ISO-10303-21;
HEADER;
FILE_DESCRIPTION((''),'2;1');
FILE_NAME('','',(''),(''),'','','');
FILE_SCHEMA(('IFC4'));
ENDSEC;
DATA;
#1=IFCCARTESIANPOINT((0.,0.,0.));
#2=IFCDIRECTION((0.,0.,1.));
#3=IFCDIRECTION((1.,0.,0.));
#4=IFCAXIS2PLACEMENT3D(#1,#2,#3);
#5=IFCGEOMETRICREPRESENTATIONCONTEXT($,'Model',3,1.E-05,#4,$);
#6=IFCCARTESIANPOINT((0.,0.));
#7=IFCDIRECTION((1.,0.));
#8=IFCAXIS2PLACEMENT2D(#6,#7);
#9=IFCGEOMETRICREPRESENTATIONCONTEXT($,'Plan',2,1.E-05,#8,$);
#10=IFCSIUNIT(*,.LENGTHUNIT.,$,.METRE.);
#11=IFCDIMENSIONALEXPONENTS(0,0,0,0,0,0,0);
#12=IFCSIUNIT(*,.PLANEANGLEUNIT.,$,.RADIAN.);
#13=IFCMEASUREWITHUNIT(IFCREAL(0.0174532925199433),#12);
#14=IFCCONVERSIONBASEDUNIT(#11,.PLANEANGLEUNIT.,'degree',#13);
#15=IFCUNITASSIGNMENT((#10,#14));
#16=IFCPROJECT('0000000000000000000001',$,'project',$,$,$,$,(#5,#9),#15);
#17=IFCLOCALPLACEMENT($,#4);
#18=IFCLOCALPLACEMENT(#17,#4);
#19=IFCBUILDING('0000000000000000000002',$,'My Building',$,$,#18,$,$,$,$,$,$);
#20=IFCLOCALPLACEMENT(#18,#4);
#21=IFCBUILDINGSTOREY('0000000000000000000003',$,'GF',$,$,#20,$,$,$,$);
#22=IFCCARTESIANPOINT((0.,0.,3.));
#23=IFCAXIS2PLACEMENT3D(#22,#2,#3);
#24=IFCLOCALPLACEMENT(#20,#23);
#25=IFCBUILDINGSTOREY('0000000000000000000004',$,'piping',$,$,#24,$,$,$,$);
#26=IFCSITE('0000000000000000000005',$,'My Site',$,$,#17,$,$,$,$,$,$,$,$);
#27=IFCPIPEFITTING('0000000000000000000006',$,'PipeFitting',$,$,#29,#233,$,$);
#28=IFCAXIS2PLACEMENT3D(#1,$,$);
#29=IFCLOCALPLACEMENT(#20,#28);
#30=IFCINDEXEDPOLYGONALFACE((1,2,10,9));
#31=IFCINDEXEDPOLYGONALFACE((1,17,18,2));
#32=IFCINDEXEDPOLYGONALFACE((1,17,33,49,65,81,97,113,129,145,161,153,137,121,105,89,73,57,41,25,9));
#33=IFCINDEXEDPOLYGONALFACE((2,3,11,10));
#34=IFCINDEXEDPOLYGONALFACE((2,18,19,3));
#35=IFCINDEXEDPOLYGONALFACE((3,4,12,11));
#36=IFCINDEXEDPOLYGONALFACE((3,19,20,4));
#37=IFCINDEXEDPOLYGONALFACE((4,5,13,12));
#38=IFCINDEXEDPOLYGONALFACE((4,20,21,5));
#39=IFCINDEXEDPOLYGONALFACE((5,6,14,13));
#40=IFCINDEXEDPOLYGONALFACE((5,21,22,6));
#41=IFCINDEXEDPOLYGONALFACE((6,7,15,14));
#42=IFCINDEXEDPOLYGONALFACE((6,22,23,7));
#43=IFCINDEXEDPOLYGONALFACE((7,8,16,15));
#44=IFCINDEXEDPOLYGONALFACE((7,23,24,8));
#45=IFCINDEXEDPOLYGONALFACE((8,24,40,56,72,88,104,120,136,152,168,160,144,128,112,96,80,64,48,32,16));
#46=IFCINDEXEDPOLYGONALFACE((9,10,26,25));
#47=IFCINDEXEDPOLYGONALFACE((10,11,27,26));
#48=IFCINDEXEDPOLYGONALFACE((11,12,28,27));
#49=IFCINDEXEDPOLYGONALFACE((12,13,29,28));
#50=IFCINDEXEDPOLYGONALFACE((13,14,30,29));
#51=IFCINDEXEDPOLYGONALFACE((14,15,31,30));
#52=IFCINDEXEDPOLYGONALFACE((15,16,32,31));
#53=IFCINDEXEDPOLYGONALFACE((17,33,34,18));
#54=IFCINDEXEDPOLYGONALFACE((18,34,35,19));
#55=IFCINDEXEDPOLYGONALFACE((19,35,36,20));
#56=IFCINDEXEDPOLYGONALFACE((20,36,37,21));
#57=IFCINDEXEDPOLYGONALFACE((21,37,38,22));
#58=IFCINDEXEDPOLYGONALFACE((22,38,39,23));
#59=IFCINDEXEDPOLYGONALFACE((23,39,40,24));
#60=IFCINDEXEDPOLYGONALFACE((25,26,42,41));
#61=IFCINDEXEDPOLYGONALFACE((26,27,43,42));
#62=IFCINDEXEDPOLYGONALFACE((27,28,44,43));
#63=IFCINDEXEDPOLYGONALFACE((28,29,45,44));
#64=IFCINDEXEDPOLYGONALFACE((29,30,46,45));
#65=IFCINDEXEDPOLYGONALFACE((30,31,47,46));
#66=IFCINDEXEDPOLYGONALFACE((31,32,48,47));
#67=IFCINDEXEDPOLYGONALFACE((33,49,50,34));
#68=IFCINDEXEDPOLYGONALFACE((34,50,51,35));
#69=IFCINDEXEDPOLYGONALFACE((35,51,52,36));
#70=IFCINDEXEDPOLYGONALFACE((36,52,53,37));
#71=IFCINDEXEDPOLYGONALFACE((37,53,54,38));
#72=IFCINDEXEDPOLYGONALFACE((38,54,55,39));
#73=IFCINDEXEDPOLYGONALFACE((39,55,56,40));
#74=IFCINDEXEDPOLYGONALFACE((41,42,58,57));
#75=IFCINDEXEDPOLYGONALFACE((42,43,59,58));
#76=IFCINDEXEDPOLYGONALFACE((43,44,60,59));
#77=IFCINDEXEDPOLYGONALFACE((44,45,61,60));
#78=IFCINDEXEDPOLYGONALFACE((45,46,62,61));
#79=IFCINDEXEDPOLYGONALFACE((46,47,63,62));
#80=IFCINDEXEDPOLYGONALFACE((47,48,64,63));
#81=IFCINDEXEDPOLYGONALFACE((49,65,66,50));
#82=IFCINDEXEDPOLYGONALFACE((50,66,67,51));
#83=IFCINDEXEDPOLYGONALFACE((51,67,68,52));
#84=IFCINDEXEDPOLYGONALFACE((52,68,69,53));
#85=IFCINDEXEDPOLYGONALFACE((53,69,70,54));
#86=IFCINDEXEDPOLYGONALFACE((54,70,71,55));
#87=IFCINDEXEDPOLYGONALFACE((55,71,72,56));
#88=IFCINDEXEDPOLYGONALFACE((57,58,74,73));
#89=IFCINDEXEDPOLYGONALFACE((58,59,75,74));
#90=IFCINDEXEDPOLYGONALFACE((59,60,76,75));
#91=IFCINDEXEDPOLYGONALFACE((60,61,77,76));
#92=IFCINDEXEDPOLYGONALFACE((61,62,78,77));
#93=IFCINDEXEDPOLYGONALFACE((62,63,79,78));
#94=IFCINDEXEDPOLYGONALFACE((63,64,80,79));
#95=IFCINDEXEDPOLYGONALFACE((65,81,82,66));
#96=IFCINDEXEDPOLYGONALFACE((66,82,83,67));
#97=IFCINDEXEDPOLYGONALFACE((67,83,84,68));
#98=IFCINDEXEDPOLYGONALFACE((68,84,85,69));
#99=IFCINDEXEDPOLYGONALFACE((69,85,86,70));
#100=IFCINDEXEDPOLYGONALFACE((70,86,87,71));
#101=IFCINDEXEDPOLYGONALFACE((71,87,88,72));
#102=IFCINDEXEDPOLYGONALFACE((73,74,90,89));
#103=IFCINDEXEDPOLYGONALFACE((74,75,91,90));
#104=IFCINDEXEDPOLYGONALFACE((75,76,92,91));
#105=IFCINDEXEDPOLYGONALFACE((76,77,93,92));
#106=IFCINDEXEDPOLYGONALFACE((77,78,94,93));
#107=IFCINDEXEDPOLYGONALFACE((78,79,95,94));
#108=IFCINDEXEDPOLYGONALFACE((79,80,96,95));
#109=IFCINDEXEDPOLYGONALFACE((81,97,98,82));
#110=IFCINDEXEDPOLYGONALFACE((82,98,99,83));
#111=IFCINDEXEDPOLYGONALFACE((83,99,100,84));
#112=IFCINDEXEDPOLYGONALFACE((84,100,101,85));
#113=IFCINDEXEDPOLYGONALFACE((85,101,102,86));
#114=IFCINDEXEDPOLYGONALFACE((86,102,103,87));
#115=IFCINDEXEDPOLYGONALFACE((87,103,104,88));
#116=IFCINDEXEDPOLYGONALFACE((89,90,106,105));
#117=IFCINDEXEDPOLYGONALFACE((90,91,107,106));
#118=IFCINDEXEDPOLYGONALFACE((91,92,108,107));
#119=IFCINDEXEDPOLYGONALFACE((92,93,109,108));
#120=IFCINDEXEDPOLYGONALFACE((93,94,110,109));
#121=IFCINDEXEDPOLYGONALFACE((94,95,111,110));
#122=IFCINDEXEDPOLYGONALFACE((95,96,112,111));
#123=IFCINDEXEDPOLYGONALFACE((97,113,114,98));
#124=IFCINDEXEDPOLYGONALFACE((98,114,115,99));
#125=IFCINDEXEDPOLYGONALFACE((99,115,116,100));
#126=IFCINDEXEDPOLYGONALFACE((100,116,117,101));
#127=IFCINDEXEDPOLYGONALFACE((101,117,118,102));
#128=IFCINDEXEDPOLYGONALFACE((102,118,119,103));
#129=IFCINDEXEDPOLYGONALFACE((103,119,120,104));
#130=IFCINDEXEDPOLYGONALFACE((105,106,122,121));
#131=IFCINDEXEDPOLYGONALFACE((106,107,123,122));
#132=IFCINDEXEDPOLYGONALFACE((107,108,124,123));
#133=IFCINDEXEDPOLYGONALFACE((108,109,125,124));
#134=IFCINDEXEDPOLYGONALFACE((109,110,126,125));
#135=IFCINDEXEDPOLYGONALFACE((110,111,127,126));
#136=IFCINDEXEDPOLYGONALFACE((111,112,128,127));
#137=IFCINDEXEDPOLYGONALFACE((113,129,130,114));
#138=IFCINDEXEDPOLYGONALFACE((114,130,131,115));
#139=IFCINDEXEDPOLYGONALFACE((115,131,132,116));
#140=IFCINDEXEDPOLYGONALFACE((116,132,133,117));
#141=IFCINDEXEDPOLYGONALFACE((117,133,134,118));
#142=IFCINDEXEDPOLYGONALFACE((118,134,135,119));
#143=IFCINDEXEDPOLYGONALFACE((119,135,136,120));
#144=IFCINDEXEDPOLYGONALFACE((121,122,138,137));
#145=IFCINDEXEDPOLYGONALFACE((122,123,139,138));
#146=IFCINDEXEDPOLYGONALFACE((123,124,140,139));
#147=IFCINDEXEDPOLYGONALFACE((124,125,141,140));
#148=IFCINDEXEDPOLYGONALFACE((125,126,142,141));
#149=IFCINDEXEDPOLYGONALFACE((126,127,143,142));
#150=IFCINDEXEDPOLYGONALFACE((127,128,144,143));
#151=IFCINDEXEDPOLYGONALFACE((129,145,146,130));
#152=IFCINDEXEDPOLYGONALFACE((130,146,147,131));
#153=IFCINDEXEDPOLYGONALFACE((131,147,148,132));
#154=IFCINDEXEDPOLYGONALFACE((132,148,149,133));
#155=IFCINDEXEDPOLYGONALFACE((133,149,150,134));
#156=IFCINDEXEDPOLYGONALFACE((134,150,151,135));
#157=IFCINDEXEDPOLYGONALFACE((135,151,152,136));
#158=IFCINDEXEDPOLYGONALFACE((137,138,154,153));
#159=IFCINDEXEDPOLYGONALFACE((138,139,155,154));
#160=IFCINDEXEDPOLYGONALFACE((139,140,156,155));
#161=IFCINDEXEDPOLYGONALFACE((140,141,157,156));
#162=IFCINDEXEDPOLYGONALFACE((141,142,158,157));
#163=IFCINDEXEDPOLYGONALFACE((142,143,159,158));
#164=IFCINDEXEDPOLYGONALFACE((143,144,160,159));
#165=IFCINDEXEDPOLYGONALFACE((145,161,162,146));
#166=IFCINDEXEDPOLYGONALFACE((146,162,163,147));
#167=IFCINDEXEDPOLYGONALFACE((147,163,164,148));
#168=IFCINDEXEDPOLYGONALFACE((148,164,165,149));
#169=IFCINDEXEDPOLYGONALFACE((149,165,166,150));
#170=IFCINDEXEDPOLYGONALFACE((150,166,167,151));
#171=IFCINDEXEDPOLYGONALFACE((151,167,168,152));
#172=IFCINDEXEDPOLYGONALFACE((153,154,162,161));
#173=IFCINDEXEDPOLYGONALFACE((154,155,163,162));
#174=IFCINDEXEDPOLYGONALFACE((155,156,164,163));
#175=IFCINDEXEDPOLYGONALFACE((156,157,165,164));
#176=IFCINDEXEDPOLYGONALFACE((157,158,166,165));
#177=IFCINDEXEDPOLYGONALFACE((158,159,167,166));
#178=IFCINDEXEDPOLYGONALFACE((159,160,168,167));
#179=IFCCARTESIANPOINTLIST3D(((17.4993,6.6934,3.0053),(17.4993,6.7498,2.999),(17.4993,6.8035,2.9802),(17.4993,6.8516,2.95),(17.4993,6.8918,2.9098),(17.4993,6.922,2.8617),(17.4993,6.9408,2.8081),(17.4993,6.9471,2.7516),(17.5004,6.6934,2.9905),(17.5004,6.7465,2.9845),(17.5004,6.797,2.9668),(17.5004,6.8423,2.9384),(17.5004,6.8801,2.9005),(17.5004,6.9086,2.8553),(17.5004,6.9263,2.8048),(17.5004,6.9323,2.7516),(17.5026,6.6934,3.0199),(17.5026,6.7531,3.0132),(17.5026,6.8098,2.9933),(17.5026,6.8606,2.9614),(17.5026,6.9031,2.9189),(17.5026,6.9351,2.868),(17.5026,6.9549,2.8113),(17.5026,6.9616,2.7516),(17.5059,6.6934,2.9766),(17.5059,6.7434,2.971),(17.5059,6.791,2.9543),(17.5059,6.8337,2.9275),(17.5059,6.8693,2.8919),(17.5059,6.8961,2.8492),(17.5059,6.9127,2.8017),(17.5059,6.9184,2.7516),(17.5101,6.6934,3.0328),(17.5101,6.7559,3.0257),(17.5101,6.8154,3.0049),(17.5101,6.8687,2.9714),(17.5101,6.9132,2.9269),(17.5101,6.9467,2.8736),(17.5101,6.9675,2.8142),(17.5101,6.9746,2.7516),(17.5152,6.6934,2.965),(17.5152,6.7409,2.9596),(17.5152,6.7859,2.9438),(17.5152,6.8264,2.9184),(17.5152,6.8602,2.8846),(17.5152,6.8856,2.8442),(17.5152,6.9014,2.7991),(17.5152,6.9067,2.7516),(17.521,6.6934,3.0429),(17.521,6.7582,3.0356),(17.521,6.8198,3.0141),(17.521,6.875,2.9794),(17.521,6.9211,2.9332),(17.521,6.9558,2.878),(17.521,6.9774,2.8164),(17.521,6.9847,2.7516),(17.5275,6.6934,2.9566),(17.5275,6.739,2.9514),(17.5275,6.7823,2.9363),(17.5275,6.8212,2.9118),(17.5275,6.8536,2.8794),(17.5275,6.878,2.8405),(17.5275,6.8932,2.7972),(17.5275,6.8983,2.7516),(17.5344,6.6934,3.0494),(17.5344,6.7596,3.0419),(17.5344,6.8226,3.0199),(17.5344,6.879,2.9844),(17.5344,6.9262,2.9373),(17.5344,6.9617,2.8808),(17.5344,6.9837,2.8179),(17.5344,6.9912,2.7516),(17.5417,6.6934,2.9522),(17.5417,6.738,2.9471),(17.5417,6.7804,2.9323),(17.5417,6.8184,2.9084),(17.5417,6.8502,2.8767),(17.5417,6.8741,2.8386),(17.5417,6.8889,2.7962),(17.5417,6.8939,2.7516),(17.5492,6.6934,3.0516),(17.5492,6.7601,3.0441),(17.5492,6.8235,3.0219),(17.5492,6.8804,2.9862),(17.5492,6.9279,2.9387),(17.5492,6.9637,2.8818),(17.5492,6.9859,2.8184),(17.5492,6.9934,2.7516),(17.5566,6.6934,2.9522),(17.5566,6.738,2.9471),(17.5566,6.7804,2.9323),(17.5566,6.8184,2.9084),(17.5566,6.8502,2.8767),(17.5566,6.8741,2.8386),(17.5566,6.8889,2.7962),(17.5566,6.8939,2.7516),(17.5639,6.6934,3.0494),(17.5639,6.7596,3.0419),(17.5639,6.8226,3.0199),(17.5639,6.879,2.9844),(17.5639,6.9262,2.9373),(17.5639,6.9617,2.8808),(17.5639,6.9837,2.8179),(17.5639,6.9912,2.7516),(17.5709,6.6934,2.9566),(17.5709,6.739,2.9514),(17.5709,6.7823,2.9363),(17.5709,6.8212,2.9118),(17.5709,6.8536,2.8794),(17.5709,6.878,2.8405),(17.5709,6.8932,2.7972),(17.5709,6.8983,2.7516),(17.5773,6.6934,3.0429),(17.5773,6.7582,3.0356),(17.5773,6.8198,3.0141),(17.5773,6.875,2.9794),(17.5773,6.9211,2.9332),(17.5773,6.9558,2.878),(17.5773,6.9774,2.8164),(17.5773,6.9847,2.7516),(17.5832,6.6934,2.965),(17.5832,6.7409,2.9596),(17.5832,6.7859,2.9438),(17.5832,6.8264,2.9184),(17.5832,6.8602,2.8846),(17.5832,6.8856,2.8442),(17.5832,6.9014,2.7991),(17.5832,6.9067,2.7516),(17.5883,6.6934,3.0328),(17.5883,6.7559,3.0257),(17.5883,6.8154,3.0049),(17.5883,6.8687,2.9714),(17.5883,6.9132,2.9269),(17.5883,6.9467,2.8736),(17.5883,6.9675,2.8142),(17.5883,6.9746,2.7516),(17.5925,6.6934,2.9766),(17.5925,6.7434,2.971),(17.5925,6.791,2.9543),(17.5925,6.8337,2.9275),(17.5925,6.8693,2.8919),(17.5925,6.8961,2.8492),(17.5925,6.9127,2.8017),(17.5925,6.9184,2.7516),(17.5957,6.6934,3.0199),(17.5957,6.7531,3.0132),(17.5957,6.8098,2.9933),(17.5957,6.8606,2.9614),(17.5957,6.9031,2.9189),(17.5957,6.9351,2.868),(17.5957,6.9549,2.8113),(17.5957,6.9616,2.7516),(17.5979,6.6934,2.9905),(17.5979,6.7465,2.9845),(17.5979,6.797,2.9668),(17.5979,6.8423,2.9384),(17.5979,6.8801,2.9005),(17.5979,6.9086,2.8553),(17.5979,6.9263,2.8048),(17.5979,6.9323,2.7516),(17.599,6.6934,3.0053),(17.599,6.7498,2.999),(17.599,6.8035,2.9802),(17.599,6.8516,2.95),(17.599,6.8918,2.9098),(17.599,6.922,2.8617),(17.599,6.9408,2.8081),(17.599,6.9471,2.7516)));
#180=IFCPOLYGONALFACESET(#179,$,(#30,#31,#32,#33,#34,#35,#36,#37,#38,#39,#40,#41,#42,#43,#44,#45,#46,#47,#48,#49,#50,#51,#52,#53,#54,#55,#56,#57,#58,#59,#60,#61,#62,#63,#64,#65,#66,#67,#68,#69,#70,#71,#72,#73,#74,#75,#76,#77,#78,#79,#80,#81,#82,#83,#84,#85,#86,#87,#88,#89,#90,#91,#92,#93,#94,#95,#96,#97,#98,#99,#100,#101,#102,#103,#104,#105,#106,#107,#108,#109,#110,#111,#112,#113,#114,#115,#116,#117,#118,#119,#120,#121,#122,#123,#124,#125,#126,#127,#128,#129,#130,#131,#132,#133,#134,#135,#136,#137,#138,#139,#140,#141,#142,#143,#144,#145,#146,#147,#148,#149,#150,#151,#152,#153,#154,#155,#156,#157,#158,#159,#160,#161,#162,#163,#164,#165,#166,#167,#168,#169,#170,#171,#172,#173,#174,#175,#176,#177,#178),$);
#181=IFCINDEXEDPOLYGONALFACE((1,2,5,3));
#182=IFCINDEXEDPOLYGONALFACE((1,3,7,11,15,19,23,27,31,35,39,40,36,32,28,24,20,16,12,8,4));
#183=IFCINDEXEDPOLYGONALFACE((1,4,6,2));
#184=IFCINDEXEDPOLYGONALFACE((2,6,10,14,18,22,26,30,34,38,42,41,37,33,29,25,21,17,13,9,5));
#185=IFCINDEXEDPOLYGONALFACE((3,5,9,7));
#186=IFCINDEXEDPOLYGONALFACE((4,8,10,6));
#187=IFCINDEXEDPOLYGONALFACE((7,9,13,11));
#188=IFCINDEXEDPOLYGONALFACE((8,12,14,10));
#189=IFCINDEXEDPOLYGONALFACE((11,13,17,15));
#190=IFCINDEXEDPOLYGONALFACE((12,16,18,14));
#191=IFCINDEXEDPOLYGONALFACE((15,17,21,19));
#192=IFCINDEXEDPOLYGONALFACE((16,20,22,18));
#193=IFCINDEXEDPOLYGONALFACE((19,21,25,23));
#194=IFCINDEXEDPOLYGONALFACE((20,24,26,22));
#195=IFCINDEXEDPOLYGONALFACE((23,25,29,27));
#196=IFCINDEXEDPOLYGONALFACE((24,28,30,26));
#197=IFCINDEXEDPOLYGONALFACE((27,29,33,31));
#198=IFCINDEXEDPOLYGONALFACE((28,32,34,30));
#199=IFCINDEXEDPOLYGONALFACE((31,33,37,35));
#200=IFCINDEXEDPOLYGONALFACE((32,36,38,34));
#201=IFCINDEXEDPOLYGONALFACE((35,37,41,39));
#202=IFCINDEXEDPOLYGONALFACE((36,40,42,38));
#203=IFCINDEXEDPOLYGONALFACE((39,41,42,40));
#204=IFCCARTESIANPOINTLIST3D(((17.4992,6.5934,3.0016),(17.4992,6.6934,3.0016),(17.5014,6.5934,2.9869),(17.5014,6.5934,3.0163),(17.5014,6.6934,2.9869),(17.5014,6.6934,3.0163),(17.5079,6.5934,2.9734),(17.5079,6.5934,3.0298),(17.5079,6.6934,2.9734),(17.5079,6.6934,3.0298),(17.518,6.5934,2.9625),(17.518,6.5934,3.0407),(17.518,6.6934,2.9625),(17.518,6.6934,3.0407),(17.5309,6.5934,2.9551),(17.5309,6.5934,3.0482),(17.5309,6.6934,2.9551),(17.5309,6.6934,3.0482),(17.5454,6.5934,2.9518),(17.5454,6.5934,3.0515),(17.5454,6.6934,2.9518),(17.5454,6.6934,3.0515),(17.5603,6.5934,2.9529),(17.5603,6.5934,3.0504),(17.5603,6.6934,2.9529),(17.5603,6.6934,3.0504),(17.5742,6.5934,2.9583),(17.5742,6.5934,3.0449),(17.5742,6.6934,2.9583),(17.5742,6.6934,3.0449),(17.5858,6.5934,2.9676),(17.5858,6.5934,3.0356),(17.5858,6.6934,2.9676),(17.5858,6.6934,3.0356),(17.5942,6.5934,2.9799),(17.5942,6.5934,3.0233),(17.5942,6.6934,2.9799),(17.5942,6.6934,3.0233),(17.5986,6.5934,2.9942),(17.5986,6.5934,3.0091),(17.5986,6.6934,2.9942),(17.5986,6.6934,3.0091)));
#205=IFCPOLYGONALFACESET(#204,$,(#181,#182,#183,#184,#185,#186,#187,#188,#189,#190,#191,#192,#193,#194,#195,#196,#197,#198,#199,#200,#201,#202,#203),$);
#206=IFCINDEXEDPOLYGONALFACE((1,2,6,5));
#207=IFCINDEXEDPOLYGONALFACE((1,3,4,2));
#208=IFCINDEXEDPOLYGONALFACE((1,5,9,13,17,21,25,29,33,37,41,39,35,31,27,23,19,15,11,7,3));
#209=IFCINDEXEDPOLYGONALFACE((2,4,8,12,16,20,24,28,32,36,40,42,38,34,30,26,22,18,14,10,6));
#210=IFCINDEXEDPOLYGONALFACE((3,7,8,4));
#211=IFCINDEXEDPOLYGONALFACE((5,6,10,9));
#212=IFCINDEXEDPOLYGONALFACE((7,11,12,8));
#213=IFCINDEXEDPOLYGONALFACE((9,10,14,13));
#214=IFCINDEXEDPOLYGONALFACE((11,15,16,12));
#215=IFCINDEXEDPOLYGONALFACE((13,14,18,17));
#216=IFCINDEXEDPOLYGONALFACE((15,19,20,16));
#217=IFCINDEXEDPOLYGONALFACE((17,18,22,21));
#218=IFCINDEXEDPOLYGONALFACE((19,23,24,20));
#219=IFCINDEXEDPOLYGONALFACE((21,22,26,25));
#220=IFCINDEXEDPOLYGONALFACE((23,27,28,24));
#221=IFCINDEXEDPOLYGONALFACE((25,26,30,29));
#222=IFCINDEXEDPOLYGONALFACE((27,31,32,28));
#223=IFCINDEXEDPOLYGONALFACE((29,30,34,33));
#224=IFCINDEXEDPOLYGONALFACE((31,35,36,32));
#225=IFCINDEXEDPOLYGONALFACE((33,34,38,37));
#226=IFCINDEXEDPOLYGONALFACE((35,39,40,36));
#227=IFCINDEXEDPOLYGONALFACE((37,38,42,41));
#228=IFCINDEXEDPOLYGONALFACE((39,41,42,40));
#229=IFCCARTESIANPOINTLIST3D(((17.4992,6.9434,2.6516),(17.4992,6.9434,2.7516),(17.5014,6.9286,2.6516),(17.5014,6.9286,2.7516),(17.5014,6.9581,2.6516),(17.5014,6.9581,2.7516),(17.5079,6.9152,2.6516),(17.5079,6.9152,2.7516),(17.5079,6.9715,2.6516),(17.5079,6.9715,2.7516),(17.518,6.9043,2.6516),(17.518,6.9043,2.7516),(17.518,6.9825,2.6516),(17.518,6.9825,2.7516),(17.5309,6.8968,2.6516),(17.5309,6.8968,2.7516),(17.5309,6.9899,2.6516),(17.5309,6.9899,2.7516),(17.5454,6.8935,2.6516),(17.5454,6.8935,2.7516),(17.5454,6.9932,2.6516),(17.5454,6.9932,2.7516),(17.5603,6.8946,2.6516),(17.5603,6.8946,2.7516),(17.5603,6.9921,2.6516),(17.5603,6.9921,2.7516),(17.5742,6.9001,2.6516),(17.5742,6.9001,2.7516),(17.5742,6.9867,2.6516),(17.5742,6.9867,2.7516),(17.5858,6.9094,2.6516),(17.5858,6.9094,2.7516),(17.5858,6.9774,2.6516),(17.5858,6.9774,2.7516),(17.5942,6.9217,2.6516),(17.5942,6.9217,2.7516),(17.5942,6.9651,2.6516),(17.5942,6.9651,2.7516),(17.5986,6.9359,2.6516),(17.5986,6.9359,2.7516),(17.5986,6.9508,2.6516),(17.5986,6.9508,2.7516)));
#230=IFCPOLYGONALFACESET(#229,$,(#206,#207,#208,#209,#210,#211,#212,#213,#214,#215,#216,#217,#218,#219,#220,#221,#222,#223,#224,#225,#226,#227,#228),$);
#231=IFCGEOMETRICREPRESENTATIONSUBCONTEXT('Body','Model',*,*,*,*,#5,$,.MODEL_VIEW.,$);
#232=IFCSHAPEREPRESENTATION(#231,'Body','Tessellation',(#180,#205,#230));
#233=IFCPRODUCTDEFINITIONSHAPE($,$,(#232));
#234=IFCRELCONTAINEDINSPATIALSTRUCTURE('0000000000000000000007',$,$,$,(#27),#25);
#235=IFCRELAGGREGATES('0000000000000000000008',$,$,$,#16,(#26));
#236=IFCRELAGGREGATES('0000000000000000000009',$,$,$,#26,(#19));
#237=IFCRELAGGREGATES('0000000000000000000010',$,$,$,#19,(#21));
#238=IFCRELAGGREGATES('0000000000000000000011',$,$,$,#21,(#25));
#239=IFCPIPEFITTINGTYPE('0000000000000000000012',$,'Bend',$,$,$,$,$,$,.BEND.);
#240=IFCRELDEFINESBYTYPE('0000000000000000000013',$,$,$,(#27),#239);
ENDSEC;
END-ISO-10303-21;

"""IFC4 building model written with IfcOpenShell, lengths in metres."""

from ifc_helpers import new_model, entity, si_unit, converted_unit, frame, origin_with_axes, origin_2d_with_axis, place, context, subcontext, project, spatial, circle, extrude, source, transform, mapped, type_object, type_shapes, element, save


model = new_model("IFC4")

# Units and contexts
model_context = context("Model", 3, precision=1e-05, world=origin_with_axes())
plan_context = context("Plan", 2, precision=1e-05, world=origin_2d_with_axis())
body_context = subcontext(model_context, "Body", "Model", "MODEL_VIEW")
ifc_project = project(units=[si_unit("LENGTHUNIT", "METRE"), converted_unit("PLANEANGLEUNIT", "degree", entity("IfcReal", 0.0174532925199433), si_unit("PLANEANGLEUNIT", "RADIAN"), dimensions=[0, 0, 0, 0, 0, 0, 0])], contexts=[model_context, plan_context])

# Site, building, storeys
site_placement = place(None, origin_with_axes())
site = spatial("IfcSite", under=ifc_project, at=site_placement, Name="My Site")
building_placement = place(site_placement, origin_with_axes())
building = spatial("IfcBuilding", under=site, at=building_placement, Name="My Building")
storey_1_placement = place(building_placement, origin_with_axes())
storey_1 = spatial("IfcBuildingStorey", under=building, at=storey_1_placement, Name="GF")
storey_2_placement = place(storey_1_placement, frame((0.0, 0.0, 3.0), z_axis=(0.0, 0.0, 1.0), x_axis=(1.0, 0.0, 0.0)))
storey_2 = spatial("IfcBuildingStorey", under=storey_1, at=storey_2_placement, Name="piping")

# Pipe fitting
pipe_fitting_type = type_object("IfcPipeFittingType", Name="Bend", PredefinedType="BEND")
shared_shape = source(origin_with_axes(), body_context, "Body", "SolidModel", [
    entity("IfcSweptDiskSolid", entity("IfcIndexedPolyCurve", entity("IfcCartesianPointList3D", [[0.0, 0.0, -0.1], [0.0, 0.0732, -0.2768], [0.0, 0.25, -0.35]]), [entity("IfcArcIndex", [1, 2, 3])]), 0.05),
    extrude(circle(Radius=0.05), origin_with_axes(), (0.0, 0.0, -1.0), 0.1),
    extrude(circle(Radius=0.05), frame((0.0, 0.25, -0.35), z_axis=(0.0, 1.0, 0.0), x_axis=(1.0, 0.0, 0.0)), (0.0, 0.0, 1.0), 0.1),
])
type_shapes(pipe_fitting_type, [shared_shape])
for number, where, z_axis, x_axis, name in (
    (1, (17.5492, 6.5934, 0.0016), (0.0, -1.0, 0.0), (-1.0, 0.0, 0.0), "PipeFitting"),
):
    element("IfcPipeFitting", number, at=place(storey_2_placement, frame(where, z_axis=z_axis, x_axis=x_axis)), inside=storey_2, type_object=pipe_fitting_type, Name=name, context=body_context, shape_type="MappedRepresentation", body=[
        mapped(shared_shape, transform((0.0, 0.0, 0.0), x_axis=(1.0, 0.0, 0.0), y_axis=(0.0, 1.0, 0.0), z_axis=(0.0, 0.0, 1.0), scale=1.0)),
    ])

save(model, "model.ifc")
